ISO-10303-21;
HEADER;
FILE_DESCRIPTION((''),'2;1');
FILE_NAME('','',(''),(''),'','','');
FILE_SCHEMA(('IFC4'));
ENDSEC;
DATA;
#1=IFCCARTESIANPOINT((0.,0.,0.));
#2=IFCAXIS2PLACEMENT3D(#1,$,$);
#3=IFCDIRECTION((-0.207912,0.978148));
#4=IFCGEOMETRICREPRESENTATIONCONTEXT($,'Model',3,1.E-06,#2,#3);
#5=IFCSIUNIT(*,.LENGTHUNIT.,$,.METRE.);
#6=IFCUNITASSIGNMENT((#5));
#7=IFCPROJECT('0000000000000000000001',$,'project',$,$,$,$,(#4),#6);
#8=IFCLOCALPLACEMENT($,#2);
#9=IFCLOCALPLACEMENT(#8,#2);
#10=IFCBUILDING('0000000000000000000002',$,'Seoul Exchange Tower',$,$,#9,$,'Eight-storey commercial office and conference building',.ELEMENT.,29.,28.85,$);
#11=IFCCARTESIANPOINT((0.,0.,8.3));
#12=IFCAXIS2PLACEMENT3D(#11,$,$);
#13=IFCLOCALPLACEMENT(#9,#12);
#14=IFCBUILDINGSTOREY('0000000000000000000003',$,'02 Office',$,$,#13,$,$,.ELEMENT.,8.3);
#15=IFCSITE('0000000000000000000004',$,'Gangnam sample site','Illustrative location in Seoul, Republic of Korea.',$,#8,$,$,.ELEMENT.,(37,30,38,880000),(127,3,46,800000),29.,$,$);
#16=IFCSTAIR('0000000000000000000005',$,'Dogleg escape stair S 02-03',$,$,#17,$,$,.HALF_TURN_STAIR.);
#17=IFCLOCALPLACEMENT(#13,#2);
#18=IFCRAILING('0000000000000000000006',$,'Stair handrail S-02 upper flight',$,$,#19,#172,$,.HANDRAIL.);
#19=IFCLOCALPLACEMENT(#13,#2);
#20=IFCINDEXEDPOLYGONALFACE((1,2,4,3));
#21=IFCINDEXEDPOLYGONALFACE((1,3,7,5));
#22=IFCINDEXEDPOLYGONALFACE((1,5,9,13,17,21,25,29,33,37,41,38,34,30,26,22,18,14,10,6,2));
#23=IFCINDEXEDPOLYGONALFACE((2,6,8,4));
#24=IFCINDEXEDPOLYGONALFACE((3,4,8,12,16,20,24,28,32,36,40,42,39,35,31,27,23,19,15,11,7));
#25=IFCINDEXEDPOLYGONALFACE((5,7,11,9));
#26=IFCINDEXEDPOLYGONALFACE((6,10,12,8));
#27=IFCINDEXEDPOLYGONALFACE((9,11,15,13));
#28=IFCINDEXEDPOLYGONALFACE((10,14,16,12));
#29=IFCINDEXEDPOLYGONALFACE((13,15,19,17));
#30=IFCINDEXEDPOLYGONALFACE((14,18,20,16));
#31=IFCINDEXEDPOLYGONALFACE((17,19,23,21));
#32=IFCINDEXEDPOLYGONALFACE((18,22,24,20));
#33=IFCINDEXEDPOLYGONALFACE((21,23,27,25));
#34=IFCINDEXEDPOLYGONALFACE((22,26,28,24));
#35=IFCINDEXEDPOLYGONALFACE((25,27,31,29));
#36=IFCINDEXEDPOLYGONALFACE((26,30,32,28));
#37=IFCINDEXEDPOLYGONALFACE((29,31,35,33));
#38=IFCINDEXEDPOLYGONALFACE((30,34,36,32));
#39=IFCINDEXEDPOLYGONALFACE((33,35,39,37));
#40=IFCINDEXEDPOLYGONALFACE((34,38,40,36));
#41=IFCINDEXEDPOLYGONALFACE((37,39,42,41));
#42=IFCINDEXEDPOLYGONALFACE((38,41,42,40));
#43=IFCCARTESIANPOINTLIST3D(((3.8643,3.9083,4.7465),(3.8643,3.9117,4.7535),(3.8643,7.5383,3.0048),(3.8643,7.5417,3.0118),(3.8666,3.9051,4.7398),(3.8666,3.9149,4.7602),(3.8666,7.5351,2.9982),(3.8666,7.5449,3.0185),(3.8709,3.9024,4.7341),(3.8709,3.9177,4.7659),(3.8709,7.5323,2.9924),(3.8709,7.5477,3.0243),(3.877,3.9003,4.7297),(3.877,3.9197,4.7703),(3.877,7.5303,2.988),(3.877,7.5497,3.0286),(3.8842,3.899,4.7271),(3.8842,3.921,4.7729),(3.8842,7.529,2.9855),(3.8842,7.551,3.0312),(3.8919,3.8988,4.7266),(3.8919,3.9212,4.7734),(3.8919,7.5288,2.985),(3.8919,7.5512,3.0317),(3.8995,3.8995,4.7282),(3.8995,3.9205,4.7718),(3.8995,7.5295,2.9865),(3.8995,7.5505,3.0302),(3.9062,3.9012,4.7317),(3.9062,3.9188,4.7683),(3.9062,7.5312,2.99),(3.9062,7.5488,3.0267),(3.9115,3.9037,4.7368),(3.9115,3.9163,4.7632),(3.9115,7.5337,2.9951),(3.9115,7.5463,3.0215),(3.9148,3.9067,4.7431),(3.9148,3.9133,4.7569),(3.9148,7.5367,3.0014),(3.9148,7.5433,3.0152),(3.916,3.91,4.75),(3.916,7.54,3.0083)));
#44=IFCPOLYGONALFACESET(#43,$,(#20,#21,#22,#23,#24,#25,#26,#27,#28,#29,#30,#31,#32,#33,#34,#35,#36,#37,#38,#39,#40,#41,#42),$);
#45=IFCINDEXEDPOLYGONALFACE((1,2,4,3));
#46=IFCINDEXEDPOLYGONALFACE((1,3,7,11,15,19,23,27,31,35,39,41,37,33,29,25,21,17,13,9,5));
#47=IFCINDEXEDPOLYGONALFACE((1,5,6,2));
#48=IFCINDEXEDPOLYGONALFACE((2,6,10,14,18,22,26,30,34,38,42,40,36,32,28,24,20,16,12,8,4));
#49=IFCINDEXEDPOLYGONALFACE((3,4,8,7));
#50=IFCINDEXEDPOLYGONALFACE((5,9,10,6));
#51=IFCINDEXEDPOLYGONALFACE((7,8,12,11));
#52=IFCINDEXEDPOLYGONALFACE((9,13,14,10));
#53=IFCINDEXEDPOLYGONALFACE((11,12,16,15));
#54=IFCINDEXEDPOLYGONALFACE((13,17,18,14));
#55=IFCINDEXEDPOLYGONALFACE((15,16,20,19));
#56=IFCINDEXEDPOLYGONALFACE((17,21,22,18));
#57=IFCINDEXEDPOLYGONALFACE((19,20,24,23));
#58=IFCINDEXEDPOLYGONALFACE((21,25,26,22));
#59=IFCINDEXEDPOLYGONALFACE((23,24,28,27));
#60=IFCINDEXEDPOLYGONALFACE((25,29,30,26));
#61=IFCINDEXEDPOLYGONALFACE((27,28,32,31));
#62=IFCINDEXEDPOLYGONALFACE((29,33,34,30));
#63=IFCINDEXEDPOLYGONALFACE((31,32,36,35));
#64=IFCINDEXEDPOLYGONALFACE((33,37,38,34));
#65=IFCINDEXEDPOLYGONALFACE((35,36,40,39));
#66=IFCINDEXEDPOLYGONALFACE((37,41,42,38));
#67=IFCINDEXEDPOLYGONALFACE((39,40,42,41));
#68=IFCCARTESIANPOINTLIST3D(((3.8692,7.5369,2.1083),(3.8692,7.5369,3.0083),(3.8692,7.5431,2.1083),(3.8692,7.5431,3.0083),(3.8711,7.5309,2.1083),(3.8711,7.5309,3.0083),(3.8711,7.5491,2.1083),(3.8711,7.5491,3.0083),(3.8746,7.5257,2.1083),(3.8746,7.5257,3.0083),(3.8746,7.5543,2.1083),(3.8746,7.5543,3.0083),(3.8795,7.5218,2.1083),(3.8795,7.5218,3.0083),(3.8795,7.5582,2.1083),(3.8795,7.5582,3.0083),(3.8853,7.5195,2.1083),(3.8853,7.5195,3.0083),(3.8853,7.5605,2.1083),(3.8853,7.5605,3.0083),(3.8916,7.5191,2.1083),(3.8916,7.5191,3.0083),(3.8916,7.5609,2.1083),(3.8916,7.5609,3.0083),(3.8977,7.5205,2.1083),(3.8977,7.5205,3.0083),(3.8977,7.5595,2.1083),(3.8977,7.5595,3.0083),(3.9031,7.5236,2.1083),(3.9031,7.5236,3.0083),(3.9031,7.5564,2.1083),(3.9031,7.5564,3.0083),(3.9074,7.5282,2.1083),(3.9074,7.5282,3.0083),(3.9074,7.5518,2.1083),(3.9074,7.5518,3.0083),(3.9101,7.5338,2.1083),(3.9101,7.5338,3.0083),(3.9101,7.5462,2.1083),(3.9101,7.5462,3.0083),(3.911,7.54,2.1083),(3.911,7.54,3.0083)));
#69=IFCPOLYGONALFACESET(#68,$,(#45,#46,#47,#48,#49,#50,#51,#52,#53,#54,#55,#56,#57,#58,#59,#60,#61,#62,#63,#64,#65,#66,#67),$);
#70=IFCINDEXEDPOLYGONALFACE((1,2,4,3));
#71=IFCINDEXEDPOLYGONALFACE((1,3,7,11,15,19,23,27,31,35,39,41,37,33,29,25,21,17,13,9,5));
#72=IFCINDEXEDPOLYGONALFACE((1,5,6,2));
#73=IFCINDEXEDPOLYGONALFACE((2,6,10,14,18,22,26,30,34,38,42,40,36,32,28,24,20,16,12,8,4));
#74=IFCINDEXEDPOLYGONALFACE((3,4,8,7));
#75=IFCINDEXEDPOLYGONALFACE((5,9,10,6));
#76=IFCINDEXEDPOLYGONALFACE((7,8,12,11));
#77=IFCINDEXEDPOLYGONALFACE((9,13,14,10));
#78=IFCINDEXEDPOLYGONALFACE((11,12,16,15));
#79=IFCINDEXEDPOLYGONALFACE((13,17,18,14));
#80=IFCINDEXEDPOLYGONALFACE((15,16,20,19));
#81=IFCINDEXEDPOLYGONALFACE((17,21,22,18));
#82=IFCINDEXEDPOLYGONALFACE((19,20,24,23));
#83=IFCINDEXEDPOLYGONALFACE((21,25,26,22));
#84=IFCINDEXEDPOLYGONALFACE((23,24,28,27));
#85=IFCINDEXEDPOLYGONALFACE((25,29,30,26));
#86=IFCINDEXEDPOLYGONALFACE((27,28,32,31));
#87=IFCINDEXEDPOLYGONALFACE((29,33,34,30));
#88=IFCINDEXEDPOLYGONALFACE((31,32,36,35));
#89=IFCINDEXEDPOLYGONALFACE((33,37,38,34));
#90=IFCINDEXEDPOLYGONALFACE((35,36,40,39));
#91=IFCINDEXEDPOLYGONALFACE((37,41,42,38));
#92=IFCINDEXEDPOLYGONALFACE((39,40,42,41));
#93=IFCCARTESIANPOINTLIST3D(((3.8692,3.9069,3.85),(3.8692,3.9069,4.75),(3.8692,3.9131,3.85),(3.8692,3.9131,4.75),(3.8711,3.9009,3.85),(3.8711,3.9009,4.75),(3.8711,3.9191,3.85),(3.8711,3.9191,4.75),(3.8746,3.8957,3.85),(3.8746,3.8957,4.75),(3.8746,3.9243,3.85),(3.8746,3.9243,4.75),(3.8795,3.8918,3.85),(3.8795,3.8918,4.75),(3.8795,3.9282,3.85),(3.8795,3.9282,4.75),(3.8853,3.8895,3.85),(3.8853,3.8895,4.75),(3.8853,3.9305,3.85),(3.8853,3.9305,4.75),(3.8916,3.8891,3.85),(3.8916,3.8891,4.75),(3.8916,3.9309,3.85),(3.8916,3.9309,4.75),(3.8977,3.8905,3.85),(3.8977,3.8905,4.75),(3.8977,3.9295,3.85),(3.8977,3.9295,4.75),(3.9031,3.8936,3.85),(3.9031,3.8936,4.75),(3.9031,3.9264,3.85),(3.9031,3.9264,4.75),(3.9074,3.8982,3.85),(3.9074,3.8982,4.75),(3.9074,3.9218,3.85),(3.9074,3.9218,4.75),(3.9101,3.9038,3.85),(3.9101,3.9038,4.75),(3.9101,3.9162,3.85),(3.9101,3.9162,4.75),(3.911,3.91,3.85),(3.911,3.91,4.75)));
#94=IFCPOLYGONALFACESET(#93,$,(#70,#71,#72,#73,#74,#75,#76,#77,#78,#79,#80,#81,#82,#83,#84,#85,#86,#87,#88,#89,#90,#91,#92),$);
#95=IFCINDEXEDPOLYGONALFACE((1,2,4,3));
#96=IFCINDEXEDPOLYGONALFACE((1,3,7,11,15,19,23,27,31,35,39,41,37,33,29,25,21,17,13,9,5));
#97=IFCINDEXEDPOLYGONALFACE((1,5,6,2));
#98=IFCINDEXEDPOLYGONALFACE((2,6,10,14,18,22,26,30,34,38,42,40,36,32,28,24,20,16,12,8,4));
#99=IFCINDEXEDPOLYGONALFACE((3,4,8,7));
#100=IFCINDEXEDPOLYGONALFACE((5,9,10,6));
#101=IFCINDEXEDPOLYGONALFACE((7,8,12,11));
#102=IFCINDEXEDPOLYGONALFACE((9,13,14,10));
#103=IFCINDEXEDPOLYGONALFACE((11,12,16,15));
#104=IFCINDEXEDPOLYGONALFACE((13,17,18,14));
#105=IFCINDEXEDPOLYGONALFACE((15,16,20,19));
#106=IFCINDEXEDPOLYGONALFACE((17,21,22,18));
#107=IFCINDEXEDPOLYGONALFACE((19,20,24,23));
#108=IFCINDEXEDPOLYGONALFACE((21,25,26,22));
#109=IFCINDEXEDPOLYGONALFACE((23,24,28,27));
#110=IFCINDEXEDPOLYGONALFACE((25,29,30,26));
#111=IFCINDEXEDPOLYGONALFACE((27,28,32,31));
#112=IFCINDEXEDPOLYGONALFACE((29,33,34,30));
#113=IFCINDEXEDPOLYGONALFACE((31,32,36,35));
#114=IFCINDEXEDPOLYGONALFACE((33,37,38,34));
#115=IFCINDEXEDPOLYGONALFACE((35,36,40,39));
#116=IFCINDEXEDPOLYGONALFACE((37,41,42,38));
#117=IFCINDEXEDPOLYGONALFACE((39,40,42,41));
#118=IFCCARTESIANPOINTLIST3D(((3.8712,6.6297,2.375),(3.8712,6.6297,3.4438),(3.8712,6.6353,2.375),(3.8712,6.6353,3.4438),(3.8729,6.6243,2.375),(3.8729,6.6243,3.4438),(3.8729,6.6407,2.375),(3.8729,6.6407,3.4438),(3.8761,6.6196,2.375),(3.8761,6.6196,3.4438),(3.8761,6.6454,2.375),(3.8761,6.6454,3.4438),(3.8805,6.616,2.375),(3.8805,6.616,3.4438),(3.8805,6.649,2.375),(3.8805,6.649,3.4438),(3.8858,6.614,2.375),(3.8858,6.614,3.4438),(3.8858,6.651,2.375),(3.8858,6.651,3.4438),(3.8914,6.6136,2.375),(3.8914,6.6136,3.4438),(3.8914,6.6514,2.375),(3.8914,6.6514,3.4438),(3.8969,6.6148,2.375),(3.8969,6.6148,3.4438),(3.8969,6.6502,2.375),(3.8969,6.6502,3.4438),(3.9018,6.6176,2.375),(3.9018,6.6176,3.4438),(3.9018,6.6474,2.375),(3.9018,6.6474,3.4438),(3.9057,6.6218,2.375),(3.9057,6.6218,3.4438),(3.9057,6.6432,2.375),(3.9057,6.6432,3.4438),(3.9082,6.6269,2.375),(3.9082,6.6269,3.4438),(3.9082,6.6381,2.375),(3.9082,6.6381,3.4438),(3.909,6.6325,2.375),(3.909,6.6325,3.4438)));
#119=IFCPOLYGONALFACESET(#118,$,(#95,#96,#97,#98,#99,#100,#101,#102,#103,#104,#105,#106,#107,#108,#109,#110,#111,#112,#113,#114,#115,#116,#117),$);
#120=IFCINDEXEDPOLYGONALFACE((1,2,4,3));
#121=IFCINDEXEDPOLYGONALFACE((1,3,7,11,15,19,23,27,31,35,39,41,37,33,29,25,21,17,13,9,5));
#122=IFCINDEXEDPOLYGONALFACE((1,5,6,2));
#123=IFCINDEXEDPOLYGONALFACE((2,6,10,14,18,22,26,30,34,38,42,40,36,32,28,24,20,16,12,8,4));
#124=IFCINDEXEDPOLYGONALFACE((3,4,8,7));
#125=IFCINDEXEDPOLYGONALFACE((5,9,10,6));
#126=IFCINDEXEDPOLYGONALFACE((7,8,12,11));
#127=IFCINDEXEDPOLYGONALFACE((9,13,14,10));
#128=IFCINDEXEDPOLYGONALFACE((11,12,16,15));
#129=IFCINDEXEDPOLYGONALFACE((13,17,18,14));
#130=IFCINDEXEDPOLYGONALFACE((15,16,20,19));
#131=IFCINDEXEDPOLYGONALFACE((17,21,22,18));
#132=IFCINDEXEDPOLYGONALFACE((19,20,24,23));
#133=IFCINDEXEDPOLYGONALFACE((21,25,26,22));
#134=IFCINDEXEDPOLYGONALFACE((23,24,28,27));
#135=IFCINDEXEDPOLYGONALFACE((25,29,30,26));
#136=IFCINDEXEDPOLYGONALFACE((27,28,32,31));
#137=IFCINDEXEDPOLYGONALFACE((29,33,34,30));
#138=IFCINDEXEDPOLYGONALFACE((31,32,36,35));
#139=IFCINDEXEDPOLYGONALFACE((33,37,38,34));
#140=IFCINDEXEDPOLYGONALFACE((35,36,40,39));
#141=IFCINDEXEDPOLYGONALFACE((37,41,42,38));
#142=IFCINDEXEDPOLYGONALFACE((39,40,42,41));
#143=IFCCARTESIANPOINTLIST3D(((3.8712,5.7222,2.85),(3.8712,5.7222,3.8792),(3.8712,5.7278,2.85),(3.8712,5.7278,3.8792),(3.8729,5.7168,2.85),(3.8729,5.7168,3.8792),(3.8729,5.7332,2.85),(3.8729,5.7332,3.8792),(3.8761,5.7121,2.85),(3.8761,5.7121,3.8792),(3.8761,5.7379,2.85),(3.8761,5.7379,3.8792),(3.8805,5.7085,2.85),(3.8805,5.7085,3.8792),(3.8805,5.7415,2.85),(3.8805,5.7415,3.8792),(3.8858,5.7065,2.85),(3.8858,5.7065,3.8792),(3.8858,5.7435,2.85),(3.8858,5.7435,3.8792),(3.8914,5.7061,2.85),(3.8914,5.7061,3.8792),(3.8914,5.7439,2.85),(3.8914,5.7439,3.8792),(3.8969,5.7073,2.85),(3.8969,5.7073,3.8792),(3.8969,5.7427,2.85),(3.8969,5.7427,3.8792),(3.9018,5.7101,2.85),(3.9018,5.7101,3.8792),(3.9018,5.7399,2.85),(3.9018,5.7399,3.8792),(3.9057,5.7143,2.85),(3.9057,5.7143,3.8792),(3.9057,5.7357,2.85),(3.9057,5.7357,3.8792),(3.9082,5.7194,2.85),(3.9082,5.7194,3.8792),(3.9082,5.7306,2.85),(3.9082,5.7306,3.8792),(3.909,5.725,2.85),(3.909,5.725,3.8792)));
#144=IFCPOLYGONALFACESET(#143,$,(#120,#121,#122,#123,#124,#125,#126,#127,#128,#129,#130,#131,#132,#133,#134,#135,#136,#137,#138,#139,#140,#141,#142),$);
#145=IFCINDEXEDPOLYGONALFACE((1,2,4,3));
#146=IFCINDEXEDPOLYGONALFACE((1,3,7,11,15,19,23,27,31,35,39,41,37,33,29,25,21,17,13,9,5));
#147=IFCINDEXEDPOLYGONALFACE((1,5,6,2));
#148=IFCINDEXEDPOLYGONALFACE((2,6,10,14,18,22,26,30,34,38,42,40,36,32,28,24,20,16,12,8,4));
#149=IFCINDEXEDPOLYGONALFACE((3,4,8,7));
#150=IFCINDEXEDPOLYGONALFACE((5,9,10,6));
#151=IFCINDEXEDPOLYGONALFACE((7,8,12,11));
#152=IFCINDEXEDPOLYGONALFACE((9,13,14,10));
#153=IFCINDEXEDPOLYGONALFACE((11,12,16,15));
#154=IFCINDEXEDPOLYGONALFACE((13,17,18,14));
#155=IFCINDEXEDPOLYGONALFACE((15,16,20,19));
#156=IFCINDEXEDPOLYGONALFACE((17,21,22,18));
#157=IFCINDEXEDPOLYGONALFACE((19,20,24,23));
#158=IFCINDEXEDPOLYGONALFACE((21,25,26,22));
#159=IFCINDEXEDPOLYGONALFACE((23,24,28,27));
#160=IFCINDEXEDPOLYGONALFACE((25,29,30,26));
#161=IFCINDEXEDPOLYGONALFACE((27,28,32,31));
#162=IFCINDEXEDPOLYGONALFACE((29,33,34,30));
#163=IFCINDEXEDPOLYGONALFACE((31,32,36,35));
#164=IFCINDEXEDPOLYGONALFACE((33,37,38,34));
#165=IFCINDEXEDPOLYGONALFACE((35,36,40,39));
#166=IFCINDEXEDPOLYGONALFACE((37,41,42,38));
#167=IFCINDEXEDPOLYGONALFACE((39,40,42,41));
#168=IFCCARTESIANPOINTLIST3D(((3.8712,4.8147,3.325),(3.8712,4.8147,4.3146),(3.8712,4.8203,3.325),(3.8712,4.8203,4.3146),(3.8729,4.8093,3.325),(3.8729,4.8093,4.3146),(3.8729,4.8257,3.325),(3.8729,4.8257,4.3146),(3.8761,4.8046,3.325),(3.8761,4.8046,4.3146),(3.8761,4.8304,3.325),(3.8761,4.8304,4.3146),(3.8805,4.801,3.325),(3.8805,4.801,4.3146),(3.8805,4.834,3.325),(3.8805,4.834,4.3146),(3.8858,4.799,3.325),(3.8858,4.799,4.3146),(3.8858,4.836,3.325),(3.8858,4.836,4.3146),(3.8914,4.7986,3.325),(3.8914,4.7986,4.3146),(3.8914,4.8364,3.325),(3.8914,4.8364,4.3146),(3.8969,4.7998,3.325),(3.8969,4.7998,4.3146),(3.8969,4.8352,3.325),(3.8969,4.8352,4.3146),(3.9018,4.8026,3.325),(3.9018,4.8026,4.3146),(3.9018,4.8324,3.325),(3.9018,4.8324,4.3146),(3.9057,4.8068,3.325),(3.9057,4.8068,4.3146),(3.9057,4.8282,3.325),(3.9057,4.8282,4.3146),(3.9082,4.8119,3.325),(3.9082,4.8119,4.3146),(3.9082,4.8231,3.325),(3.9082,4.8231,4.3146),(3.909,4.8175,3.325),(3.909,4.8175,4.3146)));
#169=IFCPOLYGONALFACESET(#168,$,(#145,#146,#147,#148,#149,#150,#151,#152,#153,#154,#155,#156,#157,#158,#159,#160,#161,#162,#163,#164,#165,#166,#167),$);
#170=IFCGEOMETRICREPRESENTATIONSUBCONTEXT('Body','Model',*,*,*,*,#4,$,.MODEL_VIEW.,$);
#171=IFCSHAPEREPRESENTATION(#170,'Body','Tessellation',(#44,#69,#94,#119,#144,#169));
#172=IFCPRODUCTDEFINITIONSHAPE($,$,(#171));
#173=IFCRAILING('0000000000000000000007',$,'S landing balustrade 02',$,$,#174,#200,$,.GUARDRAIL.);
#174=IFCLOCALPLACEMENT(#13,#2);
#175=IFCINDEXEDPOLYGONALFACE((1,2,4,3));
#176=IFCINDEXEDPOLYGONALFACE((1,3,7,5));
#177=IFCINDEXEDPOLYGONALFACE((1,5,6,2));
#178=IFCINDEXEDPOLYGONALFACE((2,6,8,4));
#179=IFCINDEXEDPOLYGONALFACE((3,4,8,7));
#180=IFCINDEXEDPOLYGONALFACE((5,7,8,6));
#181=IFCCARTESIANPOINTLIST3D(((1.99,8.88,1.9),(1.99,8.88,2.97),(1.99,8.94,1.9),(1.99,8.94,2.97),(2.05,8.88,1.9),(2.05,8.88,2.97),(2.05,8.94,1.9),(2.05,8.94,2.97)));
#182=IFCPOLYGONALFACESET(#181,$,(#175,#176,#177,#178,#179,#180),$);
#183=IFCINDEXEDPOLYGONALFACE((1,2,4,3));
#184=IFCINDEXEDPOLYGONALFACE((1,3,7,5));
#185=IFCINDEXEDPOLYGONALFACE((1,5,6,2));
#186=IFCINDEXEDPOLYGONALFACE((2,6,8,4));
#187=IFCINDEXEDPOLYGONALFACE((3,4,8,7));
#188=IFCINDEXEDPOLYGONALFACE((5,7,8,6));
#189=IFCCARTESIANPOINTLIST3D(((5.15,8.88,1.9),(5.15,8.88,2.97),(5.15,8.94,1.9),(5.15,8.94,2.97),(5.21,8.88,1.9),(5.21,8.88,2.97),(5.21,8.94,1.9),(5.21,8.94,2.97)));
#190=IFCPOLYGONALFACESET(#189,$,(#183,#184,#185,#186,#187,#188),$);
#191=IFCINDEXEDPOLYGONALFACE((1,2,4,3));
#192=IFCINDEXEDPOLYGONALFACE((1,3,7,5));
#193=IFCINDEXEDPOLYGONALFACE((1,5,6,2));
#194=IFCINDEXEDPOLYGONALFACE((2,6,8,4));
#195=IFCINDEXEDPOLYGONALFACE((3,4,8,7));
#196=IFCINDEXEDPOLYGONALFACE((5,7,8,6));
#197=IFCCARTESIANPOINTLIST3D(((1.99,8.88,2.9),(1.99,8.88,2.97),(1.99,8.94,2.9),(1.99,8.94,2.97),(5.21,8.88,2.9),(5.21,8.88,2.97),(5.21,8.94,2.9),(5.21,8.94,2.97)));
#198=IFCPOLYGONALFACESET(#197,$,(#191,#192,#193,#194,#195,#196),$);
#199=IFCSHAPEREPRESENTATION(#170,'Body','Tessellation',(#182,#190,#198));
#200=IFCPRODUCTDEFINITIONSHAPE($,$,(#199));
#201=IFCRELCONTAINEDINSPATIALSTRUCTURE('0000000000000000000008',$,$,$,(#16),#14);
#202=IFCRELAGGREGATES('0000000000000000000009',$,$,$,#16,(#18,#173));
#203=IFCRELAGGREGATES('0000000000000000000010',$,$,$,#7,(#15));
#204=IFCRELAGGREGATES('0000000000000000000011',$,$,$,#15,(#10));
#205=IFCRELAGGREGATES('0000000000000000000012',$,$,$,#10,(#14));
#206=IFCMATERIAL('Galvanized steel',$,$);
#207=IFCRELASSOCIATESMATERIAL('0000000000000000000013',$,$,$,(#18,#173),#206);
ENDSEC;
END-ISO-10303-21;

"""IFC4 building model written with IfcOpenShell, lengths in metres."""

from ifc_helpers import new_model, si_unit, direction, frame, frame_2d, origin, place, context, subcontext, project, spatial, rectangle, circle, extrude, material, element, aggregate, save


model = new_model("IFC4")

# Units and contexts
model_context = context("Model", 3, precision=1e-06, world=origin(), true_north=direction((-0.207912, 0.978148)))
body_context = subcontext(model_context, "Body", "Model", "MODEL_VIEW")
ifc_project = project(units=[si_unit("LENGTHUNIT", "METRE")], contexts=[model_context])

# Site, building, storey
site_placement = place(None, origin())
site = spatial("IfcSite", under=ifc_project, at=site_placement, Name="Gangnam sample site", Description="Illustrative location in Seoul, Republic of Korea.", CompositionType="ELEMENT", RefLatitude=(37, 30, 38, 880000), RefLongitude=(127, 3, 46, 800000), RefElevation=29.0)
building_placement = place(site_placement, origin())
building = spatial("IfcBuilding", under=site, at=building_placement, Name="Seoul Exchange Tower", LongName="Eight-storey commercial office and conference building", CompositionType="ELEMENT", ElevationOfRefHeight=29.0, ElevationOfTerrain=28.85)
storey_placement = place(building_placement, frame((0.0, 0.0, 8.3)))
storey = spatial("IfcBuildingStorey", under=building, at=storey_placement, Name="02 Office", CompositionType="ELEMENT", Elevation=8.3)

# Shared definitions
placement_1 = place(storey_placement, origin())

# Stair
placement_2 = place(placement_1, origin())
stair_1 = element("IfcStair", 1, at=placement_1, inside=storey, Name="Dogleg escape stair S 02-03", PredefinedType="HALF_TURN_STAIR")

# Railings
ifc_material_1 = material(Name="Galvanized steel")
railing_1 = element("IfcRailing", 2, at=placement_2, material=ifc_material_1, Name="Stair handrail S-02 upper flight", PredefinedType="HANDRAIL", context=body_context, shape_type="SweptSolid", body=[
    extrude(circle(Radius=0.026), frame((3.89, 7.54, 3.0083), z_axis=(0.0, -0.901594, 0.432583), x_axis=(1.0, 0.0, 0.0)), (0.0, 0.0, 1.0), 4.0262),
    extrude(circle(Radius=0.021), frame((3.89, 7.54, 2.1083), z_axis=(0.0, 0.0, 1.0), x_axis=(1.0, 0.0, 0.0)), (0.0, 0.0, 1.0), 0.9),
    extrude(circle(Radius=0.021), frame((3.89, 3.91, 3.85), z_axis=(0.0, 0.0, 1.0), x_axis=(1.0, 0.0, 0.0)), (0.0, 0.0, 1.0), 0.9),
    extrude(circle(Radius=0.019), frame((3.89, 6.6325, 2.375), z_axis=(0.0, 0.0, 1.0), x_axis=(1.0, 0.0, 0.0)), (0.0, 0.0, 1.0), 1.0688),
    extrude(circle(Radius=0.019), frame((3.89, 5.725, 2.85), z_axis=(0.0, 0.0, 1.0), x_axis=(1.0, 0.0, 0.0)), (0.0, 0.0, 1.0), 1.0292),
    extrude(circle(Radius=0.019), frame((3.89, 4.8175, 3.325), z_axis=(0.0, 0.0, 1.0), x_axis=(1.0, 0.0, 0.0)), (0.0, 0.0, 1.0), 0.9896),
])
railing_2 = element("IfcRailing", 3, at=placement_2, material=ifc_material_1, Name="S landing balustrade 02", PredefinedType="GUARDRAIL", context=body_context, shape_type="SweptSolid", body=[
    extrude(rectangle(XDim=0.06, YDim=0.06, at=frame_2d((0.03, 0.03))), frame((1.99, 8.88, 1.9)), (0.0, 0.0, 1.0), 1.07),
    extrude(rectangle(XDim=0.06, YDim=0.06, at=frame_2d((0.03, 0.03))), frame((5.15, 8.88, 1.9)), (0.0, 0.0, 1.0), 1.07),
    extrude(rectangle(XDim=3.22, YDim=0.06, at=frame_2d((1.61, 0.03))), frame((1.99, 8.88, 2.9)), (0.0, 0.0, 1.0), 0.07),
])
aggregate(stair_1, [railing_1, railing_2])

save(model, "model.ifc")
